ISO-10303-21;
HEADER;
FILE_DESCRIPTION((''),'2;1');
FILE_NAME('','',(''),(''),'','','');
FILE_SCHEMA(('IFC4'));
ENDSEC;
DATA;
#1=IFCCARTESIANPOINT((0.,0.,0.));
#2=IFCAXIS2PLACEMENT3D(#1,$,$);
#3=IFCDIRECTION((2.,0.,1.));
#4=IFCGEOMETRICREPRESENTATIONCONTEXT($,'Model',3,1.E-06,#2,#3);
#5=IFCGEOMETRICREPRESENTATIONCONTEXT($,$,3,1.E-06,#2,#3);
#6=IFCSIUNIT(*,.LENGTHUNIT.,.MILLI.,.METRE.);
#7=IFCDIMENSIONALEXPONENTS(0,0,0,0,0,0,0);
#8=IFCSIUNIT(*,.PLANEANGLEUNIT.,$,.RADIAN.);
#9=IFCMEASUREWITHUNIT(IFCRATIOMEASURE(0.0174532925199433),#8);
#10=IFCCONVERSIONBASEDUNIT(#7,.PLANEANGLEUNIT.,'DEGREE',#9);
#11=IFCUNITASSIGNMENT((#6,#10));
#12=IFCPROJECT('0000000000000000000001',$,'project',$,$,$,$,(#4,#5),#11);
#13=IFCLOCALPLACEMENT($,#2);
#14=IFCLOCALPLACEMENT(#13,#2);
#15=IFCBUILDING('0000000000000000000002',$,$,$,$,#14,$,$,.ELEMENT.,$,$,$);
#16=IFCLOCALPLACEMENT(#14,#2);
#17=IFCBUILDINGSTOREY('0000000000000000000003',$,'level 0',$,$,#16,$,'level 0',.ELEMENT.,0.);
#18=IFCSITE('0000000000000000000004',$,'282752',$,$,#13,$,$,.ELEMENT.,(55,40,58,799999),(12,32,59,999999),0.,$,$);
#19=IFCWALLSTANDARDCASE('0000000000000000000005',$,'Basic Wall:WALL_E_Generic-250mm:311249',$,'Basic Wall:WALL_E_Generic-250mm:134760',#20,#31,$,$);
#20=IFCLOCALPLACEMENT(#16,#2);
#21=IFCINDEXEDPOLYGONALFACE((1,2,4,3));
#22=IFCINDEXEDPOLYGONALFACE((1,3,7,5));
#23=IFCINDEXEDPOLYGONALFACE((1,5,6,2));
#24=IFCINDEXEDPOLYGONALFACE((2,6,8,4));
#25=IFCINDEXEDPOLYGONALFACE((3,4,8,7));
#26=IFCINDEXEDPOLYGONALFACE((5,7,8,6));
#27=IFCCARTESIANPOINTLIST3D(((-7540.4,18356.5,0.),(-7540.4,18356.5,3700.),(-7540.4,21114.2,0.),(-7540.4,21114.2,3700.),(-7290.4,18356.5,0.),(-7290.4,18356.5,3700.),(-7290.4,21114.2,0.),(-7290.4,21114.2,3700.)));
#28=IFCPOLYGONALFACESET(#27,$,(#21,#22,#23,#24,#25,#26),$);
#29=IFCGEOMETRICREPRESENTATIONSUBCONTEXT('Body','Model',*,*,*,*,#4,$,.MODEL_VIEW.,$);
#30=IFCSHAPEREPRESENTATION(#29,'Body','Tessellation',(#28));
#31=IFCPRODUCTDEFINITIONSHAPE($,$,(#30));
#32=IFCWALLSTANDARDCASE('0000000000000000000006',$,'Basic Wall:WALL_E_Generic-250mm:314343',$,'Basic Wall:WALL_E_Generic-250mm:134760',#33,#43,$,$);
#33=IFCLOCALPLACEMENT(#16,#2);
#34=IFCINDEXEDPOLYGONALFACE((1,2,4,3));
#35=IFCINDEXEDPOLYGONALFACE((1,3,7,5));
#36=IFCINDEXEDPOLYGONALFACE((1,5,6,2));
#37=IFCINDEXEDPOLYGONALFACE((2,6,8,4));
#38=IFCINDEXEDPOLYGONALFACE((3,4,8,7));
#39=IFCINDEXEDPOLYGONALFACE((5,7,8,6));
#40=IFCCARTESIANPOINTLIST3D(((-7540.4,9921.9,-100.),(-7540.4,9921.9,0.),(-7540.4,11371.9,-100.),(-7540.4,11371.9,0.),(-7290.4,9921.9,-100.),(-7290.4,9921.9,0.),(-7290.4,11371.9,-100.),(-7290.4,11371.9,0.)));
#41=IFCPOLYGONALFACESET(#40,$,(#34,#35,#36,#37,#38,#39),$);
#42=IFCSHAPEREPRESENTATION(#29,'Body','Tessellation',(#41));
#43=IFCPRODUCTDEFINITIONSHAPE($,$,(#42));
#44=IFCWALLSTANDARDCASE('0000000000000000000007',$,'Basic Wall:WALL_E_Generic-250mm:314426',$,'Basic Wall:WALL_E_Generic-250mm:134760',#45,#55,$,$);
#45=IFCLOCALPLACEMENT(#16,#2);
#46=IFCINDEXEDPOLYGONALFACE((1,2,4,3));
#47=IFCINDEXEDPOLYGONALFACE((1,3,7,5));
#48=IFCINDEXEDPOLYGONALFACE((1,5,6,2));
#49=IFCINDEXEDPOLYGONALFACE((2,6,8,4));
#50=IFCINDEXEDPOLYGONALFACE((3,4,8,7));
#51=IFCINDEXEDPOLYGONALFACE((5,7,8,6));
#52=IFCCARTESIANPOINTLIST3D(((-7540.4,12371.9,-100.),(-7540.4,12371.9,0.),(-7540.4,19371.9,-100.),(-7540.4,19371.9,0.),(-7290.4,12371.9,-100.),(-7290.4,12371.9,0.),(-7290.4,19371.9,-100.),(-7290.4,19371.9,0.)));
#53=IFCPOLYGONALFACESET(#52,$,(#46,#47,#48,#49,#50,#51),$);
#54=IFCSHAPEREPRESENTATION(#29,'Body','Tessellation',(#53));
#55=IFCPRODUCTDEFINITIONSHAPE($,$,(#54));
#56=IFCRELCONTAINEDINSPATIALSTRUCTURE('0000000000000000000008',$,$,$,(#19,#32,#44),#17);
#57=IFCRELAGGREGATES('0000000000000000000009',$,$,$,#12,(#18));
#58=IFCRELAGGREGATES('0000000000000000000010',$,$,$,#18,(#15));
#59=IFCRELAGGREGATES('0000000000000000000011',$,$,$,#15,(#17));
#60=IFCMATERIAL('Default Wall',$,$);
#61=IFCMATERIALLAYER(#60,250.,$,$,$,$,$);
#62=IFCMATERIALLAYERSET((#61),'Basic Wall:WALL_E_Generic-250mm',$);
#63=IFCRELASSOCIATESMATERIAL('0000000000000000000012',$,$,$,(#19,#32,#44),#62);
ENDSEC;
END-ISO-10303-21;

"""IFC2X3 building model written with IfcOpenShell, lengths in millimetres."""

from ifc_helpers import new_model, entity, si_unit, converted_unit, direction, frame, frame_2d, origin, place, context, subcontext, project, spatial, rectangle, extrude, material, layer, layer_set, layer_usage, element, save


model = new_model("IFC2X3")

# Units and contexts
model_context = context("Model", 3, precision=1e-06, world=origin(), true_north=direction((2.0, 0.0, 1.0)))
context_of_model = context(None, 3, precision=1e-06, world=origin(), true_north=direction((2.0, 0.0, 1.0)))
body_context = subcontext(model_context, "Body", "Model", "MODEL_VIEW")
ifc_project = project(units=[si_unit("LENGTHUNIT", "METRE", prefix="MILLI"), converted_unit("PLANEANGLEUNIT", "DEGREE", entity("IfcRatioMeasure", 0.0174532925199433), si_unit("PLANEANGLEUNIT", "RADIAN"), dimensions=[0, 0, 0, 0, 0, 0, 0])], contexts=[model_context, context_of_model])

# Site, building, storey
site_placement = place(None, origin())
site = spatial("IfcSite", under=ifc_project, at=site_placement, Name="282752", CompositionType="ELEMENT", RefLatitude=(55, 40, 58, 799999), RefLongitude=(12, 32, 59, 999999), RefElevation=0.0)
building_placement = place(site_placement, origin())
building = spatial("IfcBuilding", under=site, at=building_placement, CompositionType="ELEMENT")
storey_placement = place(building_placement, origin())
storey = spatial("IfcBuildingStorey", under=building, at=storey_placement, Name="level 0", LongName="level 0", CompositionType="ELEMENT", Elevation=0.0)

# Shared definitions
ifc_material_1 = material(Name="Default Wall")
ifc_layer_1 = layer(ifc_material_1, 250.0)
ifc_layer_set_1 = layer_set([ifc_layer_1], Name="Basic Wall:WALL_E_Generic-250mm")

# Walls
ifc_layer_usage_1 = layer_usage(ifc_layer_set_1, "AXIS2", "NEGATIVE", 125.0)
wall_1_placement = place(storey_placement, frame((-7415.4, 21114.2, 0.0), z_axis=(0.0, 0.0, 1.0), x_axis=(0.0, -1.0, 0.0)))
element("IfcWallStandardCase", 1, at=wall_1_placement, inside=storey, material=ifc_layer_usage_1, Name="Basic Wall:WALL_E_Generic-250mm:311249", ObjectType="Basic Wall:WALL_E_Generic-250mm:134760", context=body_context, shape_type="SweptSolid", body=[
    extrude(rectangle(XDim=2757.7, YDim=250.0, at=frame_2d((1378.8, 0.0), x_axis=(-1.0, 0.0))), origin(), (0.0, 0.0, 1.0), 3700.0),
])
ifc_layer_usage_2 = layer_usage(ifc_layer_set_1, "AXIS2", "NEGATIVE", 125.0)
wall_2_placement = place(storey_placement, frame((-7415.4, 9921.9, -100.0), z_axis=(0.0, 0.0, 1.0), x_axis=(0.0, 1.0, 0.0)))
element("IfcWallStandardCase", 2, at=wall_2_placement, inside=storey, material=ifc_layer_usage_2, Name="Basic Wall:WALL_E_Generic-250mm:314343", ObjectType="Basic Wall:WALL_E_Generic-250mm:134760", context=body_context, shape_type="SweptSolid", body=[
    extrude(rectangle(XDim=1450.0, YDim=250.0, at=frame_2d((725.0, 0.0), x_axis=(-1.0, 0.0))), origin(), (0.0, 0.0, 1.0), 100.0),
])
ifc_layer_usage_3 = layer_usage(ifc_layer_set_1, "AXIS2", "NEGATIVE", 125.0)
wall_3_placement = place(storey_placement, frame((-7415.4, 12371.9, -100.0), z_axis=(0.0, 0.0, 1.0), x_axis=(0.0, 1.0, 0.0)))
element("IfcWallStandardCase", 3, at=wall_3_placement, inside=storey, material=ifc_layer_usage_3, Name="Basic Wall:WALL_E_Generic-250mm:314426", ObjectType="Basic Wall:WALL_E_Generic-250mm:134760", context=body_context, shape_type="SweptSolid", body=[
    extrude(rectangle(XDim=7000.0, YDim=250.0, at=frame_2d((3500.0, 0.0), x_axis=(-1.0, 0.0))), origin(), (0.0, 0.0, 1.0), 100.0),
])

save(model, "model.ifc")
